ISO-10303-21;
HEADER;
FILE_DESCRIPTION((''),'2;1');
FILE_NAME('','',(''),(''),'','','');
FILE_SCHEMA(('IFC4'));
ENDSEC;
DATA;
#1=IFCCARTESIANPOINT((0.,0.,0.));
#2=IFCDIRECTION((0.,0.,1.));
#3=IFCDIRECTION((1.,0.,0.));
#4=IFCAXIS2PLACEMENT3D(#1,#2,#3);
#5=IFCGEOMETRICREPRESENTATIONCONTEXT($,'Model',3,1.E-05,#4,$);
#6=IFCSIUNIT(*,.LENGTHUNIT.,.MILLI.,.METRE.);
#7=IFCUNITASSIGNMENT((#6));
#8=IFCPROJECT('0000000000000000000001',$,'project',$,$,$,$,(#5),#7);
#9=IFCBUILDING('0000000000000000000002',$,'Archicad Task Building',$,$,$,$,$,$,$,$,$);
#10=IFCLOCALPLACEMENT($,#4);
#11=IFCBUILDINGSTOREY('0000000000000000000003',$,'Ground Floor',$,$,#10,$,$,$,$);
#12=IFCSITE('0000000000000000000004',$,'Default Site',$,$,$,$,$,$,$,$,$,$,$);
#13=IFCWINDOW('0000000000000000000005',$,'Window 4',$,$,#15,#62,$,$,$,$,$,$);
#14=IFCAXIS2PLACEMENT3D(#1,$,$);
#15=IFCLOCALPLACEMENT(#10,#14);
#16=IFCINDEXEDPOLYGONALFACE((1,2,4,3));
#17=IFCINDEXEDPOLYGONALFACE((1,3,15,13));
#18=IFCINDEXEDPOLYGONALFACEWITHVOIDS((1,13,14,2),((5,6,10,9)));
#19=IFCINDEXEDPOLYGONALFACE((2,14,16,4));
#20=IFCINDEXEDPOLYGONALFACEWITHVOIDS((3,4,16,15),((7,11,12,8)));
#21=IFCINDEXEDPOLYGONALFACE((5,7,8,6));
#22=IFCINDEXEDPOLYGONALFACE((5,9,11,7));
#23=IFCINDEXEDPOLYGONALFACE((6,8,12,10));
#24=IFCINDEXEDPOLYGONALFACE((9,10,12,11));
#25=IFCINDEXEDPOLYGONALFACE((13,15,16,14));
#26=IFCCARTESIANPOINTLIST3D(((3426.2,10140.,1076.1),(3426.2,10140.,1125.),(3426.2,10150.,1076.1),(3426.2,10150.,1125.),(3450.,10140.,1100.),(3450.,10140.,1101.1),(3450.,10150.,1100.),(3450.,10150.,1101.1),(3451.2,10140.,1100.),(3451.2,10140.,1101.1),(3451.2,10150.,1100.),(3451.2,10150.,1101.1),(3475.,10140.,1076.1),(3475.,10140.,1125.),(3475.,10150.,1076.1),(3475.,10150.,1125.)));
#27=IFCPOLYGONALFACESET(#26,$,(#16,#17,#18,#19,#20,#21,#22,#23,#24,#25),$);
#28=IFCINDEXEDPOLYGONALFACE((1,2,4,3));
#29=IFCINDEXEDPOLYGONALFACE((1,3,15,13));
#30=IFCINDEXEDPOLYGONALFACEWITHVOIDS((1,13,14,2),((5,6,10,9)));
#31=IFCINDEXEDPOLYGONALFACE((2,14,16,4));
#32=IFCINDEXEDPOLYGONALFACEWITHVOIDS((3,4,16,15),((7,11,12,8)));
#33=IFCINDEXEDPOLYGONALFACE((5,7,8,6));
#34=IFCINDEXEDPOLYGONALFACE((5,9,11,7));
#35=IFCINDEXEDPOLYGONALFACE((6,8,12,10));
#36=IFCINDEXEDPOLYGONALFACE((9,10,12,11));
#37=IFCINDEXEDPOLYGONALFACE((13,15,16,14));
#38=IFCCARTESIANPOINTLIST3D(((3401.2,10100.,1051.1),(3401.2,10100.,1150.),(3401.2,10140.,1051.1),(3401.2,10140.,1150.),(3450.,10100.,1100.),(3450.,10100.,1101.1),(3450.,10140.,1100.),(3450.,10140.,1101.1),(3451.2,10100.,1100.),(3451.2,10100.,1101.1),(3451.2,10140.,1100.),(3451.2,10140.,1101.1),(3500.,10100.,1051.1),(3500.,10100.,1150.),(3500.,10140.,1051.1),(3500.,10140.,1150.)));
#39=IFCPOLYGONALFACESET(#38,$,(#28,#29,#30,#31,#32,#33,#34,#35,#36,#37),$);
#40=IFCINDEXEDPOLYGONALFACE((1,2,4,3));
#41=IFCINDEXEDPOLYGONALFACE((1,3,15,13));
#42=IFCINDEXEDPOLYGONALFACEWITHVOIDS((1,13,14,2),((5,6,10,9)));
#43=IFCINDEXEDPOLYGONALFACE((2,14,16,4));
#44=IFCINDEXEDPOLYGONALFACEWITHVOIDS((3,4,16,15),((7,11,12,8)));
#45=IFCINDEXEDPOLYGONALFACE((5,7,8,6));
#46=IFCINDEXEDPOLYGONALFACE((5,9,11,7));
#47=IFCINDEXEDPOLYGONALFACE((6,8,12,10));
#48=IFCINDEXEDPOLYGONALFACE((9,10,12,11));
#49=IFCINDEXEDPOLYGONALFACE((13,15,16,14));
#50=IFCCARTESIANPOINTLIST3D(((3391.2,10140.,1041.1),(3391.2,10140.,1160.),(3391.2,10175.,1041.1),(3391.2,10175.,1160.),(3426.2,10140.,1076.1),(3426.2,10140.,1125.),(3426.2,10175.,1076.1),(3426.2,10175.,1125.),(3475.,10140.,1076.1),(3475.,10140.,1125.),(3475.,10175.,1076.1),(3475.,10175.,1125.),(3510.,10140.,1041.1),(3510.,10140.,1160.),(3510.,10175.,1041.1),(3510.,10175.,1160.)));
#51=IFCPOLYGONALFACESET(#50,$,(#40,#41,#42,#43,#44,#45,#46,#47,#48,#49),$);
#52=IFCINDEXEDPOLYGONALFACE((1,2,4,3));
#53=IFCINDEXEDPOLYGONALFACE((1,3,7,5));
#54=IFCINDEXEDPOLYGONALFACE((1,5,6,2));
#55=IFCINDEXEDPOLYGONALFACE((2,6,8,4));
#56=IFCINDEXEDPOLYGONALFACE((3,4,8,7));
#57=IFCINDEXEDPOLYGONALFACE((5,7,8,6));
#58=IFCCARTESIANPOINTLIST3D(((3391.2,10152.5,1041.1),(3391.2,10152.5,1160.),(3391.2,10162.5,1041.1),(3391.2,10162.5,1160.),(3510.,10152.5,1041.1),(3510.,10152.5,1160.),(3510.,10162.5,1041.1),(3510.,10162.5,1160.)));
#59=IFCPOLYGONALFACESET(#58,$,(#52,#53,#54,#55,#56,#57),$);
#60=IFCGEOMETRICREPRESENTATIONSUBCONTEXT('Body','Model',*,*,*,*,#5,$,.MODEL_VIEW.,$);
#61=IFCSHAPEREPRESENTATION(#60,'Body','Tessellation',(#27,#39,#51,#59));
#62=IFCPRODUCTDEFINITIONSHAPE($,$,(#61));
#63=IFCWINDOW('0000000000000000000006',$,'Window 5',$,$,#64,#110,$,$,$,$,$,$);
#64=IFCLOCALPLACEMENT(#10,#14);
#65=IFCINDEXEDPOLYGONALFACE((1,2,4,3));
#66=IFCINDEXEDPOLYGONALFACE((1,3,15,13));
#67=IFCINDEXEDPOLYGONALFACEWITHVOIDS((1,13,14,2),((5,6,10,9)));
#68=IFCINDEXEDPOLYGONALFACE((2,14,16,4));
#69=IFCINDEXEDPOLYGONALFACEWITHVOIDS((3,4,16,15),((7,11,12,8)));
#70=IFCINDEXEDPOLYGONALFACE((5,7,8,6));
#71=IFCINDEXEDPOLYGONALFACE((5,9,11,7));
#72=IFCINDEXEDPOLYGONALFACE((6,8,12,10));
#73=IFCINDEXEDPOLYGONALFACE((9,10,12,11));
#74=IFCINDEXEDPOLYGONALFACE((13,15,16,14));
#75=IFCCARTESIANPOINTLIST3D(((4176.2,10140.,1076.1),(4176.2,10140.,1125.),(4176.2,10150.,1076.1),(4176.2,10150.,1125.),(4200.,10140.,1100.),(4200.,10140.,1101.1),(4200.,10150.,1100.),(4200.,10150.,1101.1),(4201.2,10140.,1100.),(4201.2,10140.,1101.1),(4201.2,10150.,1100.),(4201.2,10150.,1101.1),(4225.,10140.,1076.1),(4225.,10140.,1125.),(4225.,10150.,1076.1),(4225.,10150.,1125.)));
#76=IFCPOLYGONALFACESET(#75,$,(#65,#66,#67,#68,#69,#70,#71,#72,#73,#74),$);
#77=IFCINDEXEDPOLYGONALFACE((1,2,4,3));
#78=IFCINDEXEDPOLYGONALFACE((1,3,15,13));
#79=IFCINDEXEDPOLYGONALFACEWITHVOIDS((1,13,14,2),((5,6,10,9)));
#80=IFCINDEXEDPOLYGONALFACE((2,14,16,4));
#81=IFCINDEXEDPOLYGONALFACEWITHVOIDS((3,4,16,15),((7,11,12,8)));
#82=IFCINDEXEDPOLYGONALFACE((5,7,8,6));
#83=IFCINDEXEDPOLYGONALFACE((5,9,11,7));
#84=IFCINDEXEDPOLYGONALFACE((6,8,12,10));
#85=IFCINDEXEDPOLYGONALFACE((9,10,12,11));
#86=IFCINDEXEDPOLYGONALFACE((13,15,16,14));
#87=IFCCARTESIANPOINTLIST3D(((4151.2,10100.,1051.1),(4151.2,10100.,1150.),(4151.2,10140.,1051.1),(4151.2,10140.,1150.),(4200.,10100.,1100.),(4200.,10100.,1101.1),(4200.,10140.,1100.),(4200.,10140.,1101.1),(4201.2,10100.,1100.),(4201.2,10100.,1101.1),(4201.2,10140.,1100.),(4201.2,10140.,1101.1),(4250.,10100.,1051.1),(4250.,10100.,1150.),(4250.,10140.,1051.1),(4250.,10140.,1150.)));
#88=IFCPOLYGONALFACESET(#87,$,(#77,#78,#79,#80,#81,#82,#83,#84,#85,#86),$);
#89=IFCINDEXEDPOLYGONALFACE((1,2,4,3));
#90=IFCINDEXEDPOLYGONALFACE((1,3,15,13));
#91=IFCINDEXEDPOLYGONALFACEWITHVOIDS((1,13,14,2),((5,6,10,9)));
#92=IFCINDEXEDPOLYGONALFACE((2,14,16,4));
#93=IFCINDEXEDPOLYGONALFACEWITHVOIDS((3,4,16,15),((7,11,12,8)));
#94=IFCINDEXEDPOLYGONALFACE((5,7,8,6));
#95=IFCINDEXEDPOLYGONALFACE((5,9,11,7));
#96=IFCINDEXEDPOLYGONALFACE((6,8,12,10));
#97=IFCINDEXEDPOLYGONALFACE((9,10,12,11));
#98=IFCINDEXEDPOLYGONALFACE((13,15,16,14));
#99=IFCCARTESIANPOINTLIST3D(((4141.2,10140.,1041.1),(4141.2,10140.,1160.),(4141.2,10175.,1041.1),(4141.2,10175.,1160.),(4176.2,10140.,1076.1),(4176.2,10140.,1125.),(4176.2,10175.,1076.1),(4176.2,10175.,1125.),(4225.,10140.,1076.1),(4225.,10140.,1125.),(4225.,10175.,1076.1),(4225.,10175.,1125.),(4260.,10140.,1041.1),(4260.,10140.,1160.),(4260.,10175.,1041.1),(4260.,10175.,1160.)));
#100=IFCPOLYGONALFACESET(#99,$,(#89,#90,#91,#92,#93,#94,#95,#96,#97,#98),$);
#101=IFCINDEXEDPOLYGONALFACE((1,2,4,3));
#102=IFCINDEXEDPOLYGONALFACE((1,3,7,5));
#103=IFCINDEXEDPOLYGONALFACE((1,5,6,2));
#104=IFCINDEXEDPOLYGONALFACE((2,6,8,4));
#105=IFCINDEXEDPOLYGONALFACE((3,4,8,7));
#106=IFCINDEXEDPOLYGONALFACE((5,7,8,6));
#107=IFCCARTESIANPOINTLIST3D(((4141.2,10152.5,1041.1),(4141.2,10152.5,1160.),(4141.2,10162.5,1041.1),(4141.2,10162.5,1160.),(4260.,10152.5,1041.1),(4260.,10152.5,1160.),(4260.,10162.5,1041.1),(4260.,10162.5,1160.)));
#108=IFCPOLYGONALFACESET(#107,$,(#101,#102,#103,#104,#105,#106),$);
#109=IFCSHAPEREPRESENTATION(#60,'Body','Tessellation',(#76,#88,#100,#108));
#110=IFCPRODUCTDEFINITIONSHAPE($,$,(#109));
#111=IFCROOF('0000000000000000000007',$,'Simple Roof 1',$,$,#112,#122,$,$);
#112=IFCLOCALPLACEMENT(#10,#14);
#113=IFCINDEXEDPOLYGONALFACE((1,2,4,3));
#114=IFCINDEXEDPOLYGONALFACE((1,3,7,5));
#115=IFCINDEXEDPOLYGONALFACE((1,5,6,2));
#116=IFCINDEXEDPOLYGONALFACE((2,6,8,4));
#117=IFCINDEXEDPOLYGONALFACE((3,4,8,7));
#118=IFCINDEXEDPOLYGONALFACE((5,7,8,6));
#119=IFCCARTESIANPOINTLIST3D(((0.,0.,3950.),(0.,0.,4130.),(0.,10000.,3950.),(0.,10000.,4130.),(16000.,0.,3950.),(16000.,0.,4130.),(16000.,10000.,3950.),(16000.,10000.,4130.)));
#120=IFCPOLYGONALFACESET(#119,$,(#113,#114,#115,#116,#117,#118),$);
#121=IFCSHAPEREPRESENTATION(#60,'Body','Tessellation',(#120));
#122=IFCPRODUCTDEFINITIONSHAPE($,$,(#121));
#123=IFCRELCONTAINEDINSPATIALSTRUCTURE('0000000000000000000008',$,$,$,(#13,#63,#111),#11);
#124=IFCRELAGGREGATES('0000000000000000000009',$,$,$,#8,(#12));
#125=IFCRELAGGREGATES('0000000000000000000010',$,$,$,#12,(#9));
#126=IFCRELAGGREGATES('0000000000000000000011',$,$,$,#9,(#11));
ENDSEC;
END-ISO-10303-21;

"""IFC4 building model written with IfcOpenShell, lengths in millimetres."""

from ifc_helpers import new_model, si_unit, frame, origin_with_axes, place, context, subcontext, project, spatial, line, indexed_curve, outline, extrude, element, save


model = new_model("IFC4")

# Units and contexts
model_context = context("Model", 3, precision=1e-05, world=origin_with_axes())
body_context = subcontext(model_context, "Body", "Model", "MODEL_VIEW")
ifc_project = project(units=[si_unit("LENGTHUNIT", "METRE", prefix="MILLI")], contexts=[model_context])

# Site, building, storey
site = spatial("IfcSite", under=ifc_project, Name="Default Site")
building = spatial("IfcBuilding", under=site, Name="Archicad Task Building")
storey_placement = place(None, origin_with_axes())
storey = spatial("IfcBuildingStorey", under=building, at=storey_placement, Name="Ground Floor")

# Windows
for number, where, z_axis, x_axis, name in (
    (1, (3450.0, 10050.0, 1100.0), (0.0, 0.0, 1.0), (1.0, 0.0, 0.0), "Window 4"),
    (2, (4200.0, 10050.0, 1100.0), (0.0, 0.0, 1.0), (1.0, 0.0, 0.0), "Window 5"),
):
    element("IfcWindow", number, at=place(storey_placement, frame(where, z_axis=z_axis, x_axis=x_axis)), inside=storey, Name=name, context=body_context, shape_type="SweptSolid", body=[
        extrude(outline(indexed_curve([(0.0, 0.0), (1.2, 0.0), (1.2, 1.1), (0.0, 1.1)], segments=[line(1, 2, 3, 4, 1)]), holes=[indexed_curve([(25.0, 25.0), (-23.8, 25.0), (-23.8, -23.9), (25.0, -23.9)], segments=[line(1, 2, 3, 4, 1)])]), frame((0.0, 90.0, 0.0), z_axis=(0.0, -1.0, 0.0), x_axis=(1.0, 0.0, 0.0)), (0.0, 0.0, -1.0), 10.0),
        extrude(outline(indexed_curve([(0.0, 0.0), (1.2, 0.0), (1.2, 1.1), (0.0, 1.1)], segments=[line(1, 2, 3, 4, 1)]), holes=[indexed_curve([(50.0, 50.0), (-48.8, 50.0), (-48.8, -48.9), (50.0, -48.9)], segments=[line(1, 2, 3, 4, 1)])]), frame((0.0, 50.0, 0.0), z_axis=(0.0, -1.0, 0.0), x_axis=(1.0, 0.0, 0.0)), (0.0, 0.0, -1.0), 40.0),
        extrude(outline(indexed_curve([(0.0, 0.0), (-48.8, 0.0), (-48.8, -48.9), (0.0, -48.9)], segments=[line(1, 2, 3, 4, 1)]), holes=[indexed_curve([(35.0, 35.0), (-83.8, 35.0), (-83.8, -83.9), (35.0, -83.9)], segments=[line(1, 2, 3, 4, 1)])]), frame((25.0, 90.0, 25.0), z_axis=(0.0, -1.0, 0.0), x_axis=(1.0, 0.0, 0.0)), (0.0, 0.0, -1.0), 35.0),
        extrude(outline(indexed_curve([(35.0, 35.0), (-83.8, 35.0), (-83.8, -83.9), (35.0, -83.9)], segments=[line(1, 2, 3, 4, 1)])), frame((25.0, 102.5, 25.0), z_axis=(0.0, -1.0, 0.0), x_axis=(1.0, 0.0, 0.0)), (0.0, 0.0, -1.0), 10.0),
    ])

# Roof
roof_placement = place(storey_placement, frame((0.0, 0.0, 3950.0), z_axis=(0.0, 0.0, 1.0), x_axis=(1.0, 0.0, 0.0)))
element("IfcRoof", 3, at=roof_placement, inside=storey, Name="Simple Roof 1", context=body_context, shape_type="SweptSolid", body=[
    extrude(outline(indexed_curve([(0.0, 0.0), (16000.0, 0.0), (16000.0, 10000.0), (0.0, 10000.0), (0.0, 0.0)])), None, (0.0, 0.0, 1.0), 180.0),
])

save(model, "model.ifc")
